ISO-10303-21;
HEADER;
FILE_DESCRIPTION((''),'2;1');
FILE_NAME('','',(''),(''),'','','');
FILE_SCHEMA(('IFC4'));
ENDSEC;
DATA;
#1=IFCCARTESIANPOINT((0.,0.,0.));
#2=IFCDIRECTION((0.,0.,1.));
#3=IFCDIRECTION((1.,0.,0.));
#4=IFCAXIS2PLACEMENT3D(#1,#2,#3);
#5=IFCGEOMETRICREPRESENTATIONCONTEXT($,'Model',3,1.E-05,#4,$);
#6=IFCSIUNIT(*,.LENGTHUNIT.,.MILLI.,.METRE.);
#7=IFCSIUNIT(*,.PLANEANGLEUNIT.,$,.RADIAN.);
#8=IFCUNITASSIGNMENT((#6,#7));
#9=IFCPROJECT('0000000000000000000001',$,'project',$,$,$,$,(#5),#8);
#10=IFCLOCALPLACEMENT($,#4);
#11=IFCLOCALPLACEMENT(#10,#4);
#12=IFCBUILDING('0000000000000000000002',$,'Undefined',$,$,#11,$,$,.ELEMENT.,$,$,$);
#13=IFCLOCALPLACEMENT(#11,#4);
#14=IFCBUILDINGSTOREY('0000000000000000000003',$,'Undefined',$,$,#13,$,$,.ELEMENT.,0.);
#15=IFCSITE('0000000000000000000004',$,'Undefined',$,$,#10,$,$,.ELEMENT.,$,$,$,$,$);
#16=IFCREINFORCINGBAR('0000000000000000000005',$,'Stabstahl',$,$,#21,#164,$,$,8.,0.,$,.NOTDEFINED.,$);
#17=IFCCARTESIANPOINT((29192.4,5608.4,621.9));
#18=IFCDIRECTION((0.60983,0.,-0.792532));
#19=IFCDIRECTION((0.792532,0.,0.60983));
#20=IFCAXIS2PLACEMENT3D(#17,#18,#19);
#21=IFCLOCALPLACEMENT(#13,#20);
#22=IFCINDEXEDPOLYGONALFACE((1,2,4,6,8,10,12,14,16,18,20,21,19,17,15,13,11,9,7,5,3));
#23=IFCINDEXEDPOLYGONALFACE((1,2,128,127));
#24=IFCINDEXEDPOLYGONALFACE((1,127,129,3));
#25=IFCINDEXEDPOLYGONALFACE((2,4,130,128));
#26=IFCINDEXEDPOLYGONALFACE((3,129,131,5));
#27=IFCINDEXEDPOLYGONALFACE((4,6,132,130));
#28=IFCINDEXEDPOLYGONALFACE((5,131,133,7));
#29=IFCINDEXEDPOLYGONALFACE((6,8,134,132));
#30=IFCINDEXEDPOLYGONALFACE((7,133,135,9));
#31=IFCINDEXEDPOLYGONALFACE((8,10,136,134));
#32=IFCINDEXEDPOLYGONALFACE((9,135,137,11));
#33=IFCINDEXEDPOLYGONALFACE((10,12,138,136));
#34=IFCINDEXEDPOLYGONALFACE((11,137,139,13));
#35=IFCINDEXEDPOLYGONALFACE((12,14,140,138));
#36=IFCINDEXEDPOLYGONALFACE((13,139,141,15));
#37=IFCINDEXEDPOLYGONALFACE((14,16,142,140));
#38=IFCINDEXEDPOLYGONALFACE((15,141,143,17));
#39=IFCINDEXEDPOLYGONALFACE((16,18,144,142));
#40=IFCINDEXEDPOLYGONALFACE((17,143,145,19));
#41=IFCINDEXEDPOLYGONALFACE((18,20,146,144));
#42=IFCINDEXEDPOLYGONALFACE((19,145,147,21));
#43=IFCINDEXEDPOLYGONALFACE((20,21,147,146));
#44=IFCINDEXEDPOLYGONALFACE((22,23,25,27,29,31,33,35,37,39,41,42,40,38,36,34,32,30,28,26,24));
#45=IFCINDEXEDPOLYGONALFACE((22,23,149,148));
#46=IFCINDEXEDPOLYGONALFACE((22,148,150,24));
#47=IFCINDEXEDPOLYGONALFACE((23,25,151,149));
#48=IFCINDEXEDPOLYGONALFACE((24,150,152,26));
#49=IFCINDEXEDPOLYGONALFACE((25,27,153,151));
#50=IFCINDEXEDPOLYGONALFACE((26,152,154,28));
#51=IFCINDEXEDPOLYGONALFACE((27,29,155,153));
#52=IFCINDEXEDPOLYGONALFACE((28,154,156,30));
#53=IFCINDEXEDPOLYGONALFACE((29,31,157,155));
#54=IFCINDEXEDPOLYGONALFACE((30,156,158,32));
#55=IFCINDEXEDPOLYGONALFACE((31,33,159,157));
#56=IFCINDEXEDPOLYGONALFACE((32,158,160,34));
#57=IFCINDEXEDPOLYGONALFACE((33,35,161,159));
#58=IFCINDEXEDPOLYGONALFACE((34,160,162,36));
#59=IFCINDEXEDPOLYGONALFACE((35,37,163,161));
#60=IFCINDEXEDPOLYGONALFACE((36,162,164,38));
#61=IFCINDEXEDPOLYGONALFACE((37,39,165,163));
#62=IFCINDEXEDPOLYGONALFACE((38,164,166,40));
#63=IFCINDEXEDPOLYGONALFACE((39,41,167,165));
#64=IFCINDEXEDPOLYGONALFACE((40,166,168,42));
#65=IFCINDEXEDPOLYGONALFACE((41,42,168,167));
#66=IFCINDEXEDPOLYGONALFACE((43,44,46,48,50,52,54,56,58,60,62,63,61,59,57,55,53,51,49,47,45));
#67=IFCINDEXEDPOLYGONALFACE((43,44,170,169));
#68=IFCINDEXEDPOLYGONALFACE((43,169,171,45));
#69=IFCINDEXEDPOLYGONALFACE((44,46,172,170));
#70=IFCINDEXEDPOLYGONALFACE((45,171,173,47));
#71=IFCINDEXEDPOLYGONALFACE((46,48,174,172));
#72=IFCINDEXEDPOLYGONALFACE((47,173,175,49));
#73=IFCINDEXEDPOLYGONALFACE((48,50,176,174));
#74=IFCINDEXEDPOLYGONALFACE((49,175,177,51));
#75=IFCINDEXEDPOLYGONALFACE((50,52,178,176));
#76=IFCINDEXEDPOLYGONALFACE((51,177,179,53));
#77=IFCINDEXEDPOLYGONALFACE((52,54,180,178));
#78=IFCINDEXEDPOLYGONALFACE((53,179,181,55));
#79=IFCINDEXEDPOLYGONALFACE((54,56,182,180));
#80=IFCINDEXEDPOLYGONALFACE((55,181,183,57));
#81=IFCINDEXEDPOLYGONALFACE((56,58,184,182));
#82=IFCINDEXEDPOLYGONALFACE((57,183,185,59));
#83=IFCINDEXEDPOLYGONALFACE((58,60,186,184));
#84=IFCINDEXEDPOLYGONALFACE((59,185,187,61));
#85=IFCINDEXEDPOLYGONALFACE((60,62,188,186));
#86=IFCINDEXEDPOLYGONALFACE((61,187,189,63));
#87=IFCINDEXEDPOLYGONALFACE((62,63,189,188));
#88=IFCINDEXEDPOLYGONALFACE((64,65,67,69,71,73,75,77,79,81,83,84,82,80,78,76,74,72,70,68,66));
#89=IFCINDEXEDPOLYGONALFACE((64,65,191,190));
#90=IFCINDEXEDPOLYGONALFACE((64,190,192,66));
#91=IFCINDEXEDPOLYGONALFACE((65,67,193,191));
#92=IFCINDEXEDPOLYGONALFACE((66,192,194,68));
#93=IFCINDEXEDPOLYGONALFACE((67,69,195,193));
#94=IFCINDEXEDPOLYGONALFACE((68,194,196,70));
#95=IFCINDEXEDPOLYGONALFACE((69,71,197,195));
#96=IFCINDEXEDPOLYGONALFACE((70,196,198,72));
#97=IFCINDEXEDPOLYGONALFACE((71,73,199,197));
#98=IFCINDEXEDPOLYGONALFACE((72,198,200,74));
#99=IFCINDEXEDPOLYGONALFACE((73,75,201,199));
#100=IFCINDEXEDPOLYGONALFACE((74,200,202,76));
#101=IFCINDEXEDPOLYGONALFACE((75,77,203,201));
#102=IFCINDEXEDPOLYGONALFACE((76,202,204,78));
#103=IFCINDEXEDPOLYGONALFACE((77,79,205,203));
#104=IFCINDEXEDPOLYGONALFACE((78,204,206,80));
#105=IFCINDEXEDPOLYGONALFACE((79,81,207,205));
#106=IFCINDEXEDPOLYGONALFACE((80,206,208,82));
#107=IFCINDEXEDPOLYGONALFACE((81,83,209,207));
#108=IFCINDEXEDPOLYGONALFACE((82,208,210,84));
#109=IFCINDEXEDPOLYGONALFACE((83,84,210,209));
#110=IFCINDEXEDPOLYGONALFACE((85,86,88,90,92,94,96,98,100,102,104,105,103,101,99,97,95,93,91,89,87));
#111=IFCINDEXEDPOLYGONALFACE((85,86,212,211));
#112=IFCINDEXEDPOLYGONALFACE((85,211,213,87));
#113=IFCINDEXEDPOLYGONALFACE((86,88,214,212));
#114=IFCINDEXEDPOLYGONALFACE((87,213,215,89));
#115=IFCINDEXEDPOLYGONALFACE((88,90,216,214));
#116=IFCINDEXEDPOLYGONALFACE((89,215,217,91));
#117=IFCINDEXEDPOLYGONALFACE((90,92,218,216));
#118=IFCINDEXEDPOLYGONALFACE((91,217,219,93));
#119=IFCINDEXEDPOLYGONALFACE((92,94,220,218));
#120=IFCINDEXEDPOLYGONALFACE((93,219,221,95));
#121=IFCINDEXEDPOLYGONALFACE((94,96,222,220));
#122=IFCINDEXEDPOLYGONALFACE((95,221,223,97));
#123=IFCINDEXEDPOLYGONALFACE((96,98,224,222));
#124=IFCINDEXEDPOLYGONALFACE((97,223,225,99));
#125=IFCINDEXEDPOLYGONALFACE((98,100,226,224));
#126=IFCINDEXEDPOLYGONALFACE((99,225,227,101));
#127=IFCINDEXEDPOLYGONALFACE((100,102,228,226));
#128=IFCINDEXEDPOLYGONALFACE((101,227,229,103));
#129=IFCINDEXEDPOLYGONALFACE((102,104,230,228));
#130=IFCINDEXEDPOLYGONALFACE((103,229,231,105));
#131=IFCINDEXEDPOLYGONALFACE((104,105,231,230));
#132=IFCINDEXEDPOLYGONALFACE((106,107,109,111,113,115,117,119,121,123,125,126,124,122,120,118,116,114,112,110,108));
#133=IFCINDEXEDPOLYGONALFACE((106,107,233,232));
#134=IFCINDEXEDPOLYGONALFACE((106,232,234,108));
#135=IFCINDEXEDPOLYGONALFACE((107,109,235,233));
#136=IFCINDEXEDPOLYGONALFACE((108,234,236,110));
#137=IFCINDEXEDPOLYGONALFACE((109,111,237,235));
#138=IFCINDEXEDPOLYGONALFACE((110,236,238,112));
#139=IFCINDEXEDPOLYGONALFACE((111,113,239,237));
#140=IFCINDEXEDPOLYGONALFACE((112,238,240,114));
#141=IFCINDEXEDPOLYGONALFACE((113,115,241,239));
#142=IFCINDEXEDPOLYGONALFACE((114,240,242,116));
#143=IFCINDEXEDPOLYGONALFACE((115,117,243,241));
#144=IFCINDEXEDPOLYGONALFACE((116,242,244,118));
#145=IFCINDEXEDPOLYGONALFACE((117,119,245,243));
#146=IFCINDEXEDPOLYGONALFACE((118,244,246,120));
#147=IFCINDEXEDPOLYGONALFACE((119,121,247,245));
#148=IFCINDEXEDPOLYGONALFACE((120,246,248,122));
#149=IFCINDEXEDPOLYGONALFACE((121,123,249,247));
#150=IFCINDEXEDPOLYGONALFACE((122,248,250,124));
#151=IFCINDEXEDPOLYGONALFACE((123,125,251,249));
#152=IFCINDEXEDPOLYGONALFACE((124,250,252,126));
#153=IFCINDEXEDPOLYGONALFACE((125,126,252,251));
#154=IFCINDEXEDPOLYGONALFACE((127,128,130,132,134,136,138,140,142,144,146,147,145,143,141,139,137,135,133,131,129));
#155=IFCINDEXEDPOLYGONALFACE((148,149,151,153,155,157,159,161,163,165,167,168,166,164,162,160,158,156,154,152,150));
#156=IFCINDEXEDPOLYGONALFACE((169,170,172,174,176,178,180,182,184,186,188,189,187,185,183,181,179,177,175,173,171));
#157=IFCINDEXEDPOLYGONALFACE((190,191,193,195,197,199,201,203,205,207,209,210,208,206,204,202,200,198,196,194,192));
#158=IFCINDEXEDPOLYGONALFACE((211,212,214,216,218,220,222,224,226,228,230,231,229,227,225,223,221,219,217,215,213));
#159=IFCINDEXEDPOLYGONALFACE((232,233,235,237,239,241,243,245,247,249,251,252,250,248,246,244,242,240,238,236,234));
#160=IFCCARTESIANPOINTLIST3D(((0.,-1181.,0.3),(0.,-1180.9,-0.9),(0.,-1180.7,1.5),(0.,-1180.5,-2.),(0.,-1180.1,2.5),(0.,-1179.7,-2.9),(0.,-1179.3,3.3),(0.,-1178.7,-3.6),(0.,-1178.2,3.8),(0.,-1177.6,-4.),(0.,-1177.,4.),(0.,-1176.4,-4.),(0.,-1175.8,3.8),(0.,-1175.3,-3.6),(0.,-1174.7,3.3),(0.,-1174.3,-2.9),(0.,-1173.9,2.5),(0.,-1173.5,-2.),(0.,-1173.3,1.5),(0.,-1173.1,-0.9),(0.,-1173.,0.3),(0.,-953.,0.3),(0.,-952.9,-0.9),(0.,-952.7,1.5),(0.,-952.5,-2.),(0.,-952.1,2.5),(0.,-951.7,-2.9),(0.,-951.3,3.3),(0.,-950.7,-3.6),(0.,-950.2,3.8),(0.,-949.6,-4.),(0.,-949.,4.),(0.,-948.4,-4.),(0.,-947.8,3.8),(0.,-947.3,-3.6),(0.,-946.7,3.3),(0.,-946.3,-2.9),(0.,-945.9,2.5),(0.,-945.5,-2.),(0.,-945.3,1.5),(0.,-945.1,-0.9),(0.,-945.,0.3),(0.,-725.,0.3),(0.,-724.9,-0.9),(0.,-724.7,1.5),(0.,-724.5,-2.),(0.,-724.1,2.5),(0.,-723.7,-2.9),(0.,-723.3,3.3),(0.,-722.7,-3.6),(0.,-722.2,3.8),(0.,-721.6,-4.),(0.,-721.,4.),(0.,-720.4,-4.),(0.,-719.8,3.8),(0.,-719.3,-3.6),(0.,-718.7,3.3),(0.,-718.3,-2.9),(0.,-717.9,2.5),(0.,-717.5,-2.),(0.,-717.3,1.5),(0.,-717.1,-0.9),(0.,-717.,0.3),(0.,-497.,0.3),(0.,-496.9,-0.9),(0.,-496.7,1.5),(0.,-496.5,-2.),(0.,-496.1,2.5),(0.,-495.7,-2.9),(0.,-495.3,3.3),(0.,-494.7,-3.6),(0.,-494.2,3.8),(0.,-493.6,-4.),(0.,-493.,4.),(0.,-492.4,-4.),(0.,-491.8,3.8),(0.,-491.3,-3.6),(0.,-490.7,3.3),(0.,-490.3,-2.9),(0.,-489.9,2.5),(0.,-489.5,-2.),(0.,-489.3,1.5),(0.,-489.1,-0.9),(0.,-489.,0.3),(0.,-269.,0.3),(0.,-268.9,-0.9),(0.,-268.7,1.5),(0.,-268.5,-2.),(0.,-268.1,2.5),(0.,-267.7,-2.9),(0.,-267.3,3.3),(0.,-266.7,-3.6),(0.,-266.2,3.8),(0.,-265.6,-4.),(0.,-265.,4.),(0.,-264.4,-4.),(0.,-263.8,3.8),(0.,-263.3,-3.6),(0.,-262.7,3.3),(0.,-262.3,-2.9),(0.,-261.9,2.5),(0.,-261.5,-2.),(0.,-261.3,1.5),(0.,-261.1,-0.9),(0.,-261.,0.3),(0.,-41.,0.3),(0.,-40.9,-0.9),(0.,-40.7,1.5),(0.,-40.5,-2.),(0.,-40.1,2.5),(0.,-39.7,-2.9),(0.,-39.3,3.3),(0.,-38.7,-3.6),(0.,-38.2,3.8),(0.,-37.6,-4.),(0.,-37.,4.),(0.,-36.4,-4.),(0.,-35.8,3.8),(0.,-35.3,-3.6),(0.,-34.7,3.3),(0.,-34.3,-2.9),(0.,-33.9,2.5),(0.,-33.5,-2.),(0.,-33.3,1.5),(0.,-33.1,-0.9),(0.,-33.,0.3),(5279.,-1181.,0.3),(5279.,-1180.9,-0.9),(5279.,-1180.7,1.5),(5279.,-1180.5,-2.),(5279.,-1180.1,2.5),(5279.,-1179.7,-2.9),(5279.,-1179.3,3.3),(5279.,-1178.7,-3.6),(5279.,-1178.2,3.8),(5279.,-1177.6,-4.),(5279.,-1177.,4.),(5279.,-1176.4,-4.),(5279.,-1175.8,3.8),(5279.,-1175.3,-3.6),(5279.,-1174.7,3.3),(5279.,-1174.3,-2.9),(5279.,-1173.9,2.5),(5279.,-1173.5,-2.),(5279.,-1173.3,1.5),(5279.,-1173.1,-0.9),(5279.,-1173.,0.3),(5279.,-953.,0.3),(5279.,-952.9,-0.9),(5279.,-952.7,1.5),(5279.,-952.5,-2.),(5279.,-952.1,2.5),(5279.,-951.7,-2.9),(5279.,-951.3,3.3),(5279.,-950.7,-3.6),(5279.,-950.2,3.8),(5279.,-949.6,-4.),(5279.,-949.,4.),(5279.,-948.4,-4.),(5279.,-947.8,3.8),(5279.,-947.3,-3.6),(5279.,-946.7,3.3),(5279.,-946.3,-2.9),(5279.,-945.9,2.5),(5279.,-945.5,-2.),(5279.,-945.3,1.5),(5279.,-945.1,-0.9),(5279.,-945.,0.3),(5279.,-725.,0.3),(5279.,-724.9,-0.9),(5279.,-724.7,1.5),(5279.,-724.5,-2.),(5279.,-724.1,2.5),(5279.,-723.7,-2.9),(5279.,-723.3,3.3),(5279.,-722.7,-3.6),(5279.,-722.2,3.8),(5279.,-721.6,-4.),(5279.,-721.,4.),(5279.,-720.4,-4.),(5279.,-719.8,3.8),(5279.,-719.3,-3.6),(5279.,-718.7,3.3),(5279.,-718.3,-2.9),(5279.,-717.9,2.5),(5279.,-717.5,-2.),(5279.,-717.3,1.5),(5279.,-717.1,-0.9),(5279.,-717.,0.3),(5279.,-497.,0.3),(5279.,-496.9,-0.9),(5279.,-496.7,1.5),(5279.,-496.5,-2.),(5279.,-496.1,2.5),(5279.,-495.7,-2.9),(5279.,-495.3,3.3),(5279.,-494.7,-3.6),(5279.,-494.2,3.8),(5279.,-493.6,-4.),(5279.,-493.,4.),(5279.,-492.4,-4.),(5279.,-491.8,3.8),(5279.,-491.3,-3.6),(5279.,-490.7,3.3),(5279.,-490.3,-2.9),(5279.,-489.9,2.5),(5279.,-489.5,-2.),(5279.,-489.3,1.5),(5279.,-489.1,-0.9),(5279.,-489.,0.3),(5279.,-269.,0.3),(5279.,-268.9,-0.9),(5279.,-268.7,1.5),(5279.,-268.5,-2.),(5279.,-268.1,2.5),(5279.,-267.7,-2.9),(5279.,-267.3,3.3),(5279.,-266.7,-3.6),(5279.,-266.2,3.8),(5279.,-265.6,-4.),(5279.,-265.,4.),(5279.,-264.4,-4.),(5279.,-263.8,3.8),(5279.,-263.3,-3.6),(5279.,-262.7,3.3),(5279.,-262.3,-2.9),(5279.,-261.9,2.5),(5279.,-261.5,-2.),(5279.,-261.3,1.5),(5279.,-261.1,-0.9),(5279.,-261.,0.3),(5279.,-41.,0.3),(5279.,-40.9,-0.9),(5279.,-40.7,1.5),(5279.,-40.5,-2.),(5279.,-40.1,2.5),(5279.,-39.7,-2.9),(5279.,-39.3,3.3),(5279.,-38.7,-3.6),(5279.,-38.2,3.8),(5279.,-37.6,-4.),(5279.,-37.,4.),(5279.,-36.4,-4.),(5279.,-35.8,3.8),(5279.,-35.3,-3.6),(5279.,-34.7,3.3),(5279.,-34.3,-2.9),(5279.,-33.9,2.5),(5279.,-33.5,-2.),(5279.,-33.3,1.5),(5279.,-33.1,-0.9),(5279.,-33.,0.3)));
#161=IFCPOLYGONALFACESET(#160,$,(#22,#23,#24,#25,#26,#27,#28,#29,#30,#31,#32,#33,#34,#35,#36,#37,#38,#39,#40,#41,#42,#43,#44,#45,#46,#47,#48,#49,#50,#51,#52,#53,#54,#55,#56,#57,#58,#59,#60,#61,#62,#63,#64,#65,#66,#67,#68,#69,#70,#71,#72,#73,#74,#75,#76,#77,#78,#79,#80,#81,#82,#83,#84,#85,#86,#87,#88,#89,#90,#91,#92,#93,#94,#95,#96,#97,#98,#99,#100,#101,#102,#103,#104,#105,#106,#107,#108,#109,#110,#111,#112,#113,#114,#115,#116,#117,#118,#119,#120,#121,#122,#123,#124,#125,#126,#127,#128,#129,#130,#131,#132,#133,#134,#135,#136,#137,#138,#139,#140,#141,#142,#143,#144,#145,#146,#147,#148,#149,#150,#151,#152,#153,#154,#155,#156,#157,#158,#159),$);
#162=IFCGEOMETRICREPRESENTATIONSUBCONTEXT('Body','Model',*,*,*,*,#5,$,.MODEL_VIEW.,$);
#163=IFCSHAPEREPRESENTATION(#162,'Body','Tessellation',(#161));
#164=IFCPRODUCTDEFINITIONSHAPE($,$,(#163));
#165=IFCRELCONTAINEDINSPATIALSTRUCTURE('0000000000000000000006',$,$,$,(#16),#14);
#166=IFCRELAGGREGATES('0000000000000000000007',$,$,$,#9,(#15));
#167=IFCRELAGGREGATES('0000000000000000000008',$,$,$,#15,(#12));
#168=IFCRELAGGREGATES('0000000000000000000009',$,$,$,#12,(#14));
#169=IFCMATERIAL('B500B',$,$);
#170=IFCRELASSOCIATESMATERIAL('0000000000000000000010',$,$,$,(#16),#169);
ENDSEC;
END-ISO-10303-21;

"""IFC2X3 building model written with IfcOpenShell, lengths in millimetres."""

from ifc_helpers import new_model, entity, si_unit, frame, origin_with_axes, place, context, subcontext, project, spatial, source, transform, mapped, material, element, save


model = new_model("IFC2X3")

# Units and contexts
model_context = context("Model", 3, precision=1e-05, world=origin_with_axes())
body_context = subcontext(model_context, "Body", "Model", "MODEL_VIEW")
ifc_project = project(units=[si_unit("LENGTHUNIT", "METRE", prefix="MILLI"), si_unit("PLANEANGLEUNIT", "RADIAN")], contexts=[model_context])

# Site, building, storey
site_placement = place(None, origin_with_axes())
site = spatial("IfcSite", under=ifc_project, at=site_placement, Name="Undefined", CompositionType="ELEMENT")
building_placement = place(site_placement, origin_with_axes())
building = spatial("IfcBuilding", under=site, at=building_placement, Name="Undefined", CompositionType="ELEMENT")
storey_placement = place(building_placement, origin_with_axes())
storey = spatial("IfcBuildingStorey", under=building, at=storey_placement, Name="Undefined", CompositionType="ELEMENT", Elevation=0.0)

# Reinforcing bar
ifc_material_1 = material(Name="B500B")
shared_shape_1 = source(origin_with_axes(), body_context, "Body", "AdvancedSweptSolid", [
    entity("IfcSweptDiskSolid", entity("IfcTrimmedCurve", entity("IfcLine", entity("IfcCartesianPoint", [0.0, 0.0, 0.0]), entity("IfcVector", entity("IfcDirection", [1.0, 0.0, 0.0]), 1.0)), [entity("IfcParameterValue", 0.0)], [entity("IfcParameterValue", 5278.965699)], True, "PARAMETER"), 4.0, None, 0.0, 5279.0),
])
shared_shape_2 = source(origin_with_axes(), body_context, "Body", "AdvancedSweptSolid", [
    entity("IfcSweptDiskSolid", entity("IfcTrimmedCurve", entity("IfcLine", entity("IfcCartesianPoint", [0.0, 0.0, 0.0]), entity("IfcVector", entity("IfcDirection", [1.0, 0.0, 0.0]), 1.0)), [entity("IfcParameterValue", 0.0)], [entity("IfcParameterValue", 5278.965699)], True, "PARAMETER"), 4.0, None, 0.0, 5279.0),
])
shared_shape_3 = source(origin_with_axes(), body_context, "Body", "AdvancedSweptSolid", [
    entity("IfcSweptDiskSolid", entity("IfcTrimmedCurve", entity("IfcLine", entity("IfcCartesianPoint", [0.0, 0.0, 0.0]), entity("IfcVector", entity("IfcDirection", [1.0, 0.0, 0.0]), 1.0)), [entity("IfcParameterValue", 0.0)], [entity("IfcParameterValue", 5278.965699)], True, "PARAMETER"), 4.0, None, 0.0, 5279.0),
])
shared_shape_4 = source(origin_with_axes(), body_context, "Body", "AdvancedSweptSolid", [
    entity("IfcSweptDiskSolid", entity("IfcTrimmedCurve", entity("IfcLine", entity("IfcCartesianPoint", [0.0, 0.0, 0.0]), entity("IfcVector", entity("IfcDirection", [1.0, 0.0, 0.0]), 1.0)), [entity("IfcParameterValue", 0.0)], [entity("IfcParameterValue", 5278.965699)], True, "PARAMETER"), 4.0, None, 0.0, 5279.0),
])
shared_shape_5 = source(origin_with_axes(), body_context, "Body", "AdvancedSweptSolid", [
    entity("IfcSweptDiskSolid", entity("IfcTrimmedCurve", entity("IfcLine", entity("IfcCartesianPoint", [0.0, 0.0, 0.0]), entity("IfcVector", entity("IfcDirection", [1.0, 0.0, 0.0]), 1.0)), [entity("IfcParameterValue", 0.0)], [entity("IfcParameterValue", 5278.965699)], True, "PARAMETER"), 4.0, None, 0.0, 5279.0),
])
shared_shape_6 = source(origin_with_axes(), body_context, "Body", "AdvancedSweptSolid", [
    entity("IfcSweptDiskSolid", entity("IfcTrimmedCurve", entity("IfcLine", entity("IfcCartesianPoint", [0.0, 0.0, 0.0]), entity("IfcVector", entity("IfcDirection", [1.0, 0.0, 0.0]), 1.0)), [entity("IfcParameterValue", 0.0)], [entity("IfcParameterValue", 5278.965699)], True, "PARAMETER"), 4.0, None, 0.0, 5279.0),
])
reinforcing_bar_1_placement = place(storey_placement, frame((29192.4, 5608.4, 621.9), z_axis=(0.60983, 0.0, -0.792532), x_axis=(0.792532, 0.0, 0.60983)))
element("IfcReinforcingBar", 1, at=reinforcing_bar_1_placement, inside=storey, material=ifc_material_1, Name="Stabstahl", BarRole="NOTDEFINED", CrossSectionArea=0.0, NominalDiameter=8.0, context=body_context, shape_type="MappedRepresentation", body=[
    mapped(shared_shape_1, transform((0.0, -1177.0, 0.0))),
    mapped(shared_shape_2, transform((0.0, -949.0, 0.0))),
    mapped(shared_shape_3, transform((0.0, -721.0, 0.0))),
    mapped(shared_shape_4, transform((0.0, -493.0, 0.0))),
    mapped(shared_shape_5, transform((0.0, -265.0, 0.0))),
    mapped(shared_shape_6, transform((0.0, -37.0, 0.0))),
])

save(model, "model.ifc")
